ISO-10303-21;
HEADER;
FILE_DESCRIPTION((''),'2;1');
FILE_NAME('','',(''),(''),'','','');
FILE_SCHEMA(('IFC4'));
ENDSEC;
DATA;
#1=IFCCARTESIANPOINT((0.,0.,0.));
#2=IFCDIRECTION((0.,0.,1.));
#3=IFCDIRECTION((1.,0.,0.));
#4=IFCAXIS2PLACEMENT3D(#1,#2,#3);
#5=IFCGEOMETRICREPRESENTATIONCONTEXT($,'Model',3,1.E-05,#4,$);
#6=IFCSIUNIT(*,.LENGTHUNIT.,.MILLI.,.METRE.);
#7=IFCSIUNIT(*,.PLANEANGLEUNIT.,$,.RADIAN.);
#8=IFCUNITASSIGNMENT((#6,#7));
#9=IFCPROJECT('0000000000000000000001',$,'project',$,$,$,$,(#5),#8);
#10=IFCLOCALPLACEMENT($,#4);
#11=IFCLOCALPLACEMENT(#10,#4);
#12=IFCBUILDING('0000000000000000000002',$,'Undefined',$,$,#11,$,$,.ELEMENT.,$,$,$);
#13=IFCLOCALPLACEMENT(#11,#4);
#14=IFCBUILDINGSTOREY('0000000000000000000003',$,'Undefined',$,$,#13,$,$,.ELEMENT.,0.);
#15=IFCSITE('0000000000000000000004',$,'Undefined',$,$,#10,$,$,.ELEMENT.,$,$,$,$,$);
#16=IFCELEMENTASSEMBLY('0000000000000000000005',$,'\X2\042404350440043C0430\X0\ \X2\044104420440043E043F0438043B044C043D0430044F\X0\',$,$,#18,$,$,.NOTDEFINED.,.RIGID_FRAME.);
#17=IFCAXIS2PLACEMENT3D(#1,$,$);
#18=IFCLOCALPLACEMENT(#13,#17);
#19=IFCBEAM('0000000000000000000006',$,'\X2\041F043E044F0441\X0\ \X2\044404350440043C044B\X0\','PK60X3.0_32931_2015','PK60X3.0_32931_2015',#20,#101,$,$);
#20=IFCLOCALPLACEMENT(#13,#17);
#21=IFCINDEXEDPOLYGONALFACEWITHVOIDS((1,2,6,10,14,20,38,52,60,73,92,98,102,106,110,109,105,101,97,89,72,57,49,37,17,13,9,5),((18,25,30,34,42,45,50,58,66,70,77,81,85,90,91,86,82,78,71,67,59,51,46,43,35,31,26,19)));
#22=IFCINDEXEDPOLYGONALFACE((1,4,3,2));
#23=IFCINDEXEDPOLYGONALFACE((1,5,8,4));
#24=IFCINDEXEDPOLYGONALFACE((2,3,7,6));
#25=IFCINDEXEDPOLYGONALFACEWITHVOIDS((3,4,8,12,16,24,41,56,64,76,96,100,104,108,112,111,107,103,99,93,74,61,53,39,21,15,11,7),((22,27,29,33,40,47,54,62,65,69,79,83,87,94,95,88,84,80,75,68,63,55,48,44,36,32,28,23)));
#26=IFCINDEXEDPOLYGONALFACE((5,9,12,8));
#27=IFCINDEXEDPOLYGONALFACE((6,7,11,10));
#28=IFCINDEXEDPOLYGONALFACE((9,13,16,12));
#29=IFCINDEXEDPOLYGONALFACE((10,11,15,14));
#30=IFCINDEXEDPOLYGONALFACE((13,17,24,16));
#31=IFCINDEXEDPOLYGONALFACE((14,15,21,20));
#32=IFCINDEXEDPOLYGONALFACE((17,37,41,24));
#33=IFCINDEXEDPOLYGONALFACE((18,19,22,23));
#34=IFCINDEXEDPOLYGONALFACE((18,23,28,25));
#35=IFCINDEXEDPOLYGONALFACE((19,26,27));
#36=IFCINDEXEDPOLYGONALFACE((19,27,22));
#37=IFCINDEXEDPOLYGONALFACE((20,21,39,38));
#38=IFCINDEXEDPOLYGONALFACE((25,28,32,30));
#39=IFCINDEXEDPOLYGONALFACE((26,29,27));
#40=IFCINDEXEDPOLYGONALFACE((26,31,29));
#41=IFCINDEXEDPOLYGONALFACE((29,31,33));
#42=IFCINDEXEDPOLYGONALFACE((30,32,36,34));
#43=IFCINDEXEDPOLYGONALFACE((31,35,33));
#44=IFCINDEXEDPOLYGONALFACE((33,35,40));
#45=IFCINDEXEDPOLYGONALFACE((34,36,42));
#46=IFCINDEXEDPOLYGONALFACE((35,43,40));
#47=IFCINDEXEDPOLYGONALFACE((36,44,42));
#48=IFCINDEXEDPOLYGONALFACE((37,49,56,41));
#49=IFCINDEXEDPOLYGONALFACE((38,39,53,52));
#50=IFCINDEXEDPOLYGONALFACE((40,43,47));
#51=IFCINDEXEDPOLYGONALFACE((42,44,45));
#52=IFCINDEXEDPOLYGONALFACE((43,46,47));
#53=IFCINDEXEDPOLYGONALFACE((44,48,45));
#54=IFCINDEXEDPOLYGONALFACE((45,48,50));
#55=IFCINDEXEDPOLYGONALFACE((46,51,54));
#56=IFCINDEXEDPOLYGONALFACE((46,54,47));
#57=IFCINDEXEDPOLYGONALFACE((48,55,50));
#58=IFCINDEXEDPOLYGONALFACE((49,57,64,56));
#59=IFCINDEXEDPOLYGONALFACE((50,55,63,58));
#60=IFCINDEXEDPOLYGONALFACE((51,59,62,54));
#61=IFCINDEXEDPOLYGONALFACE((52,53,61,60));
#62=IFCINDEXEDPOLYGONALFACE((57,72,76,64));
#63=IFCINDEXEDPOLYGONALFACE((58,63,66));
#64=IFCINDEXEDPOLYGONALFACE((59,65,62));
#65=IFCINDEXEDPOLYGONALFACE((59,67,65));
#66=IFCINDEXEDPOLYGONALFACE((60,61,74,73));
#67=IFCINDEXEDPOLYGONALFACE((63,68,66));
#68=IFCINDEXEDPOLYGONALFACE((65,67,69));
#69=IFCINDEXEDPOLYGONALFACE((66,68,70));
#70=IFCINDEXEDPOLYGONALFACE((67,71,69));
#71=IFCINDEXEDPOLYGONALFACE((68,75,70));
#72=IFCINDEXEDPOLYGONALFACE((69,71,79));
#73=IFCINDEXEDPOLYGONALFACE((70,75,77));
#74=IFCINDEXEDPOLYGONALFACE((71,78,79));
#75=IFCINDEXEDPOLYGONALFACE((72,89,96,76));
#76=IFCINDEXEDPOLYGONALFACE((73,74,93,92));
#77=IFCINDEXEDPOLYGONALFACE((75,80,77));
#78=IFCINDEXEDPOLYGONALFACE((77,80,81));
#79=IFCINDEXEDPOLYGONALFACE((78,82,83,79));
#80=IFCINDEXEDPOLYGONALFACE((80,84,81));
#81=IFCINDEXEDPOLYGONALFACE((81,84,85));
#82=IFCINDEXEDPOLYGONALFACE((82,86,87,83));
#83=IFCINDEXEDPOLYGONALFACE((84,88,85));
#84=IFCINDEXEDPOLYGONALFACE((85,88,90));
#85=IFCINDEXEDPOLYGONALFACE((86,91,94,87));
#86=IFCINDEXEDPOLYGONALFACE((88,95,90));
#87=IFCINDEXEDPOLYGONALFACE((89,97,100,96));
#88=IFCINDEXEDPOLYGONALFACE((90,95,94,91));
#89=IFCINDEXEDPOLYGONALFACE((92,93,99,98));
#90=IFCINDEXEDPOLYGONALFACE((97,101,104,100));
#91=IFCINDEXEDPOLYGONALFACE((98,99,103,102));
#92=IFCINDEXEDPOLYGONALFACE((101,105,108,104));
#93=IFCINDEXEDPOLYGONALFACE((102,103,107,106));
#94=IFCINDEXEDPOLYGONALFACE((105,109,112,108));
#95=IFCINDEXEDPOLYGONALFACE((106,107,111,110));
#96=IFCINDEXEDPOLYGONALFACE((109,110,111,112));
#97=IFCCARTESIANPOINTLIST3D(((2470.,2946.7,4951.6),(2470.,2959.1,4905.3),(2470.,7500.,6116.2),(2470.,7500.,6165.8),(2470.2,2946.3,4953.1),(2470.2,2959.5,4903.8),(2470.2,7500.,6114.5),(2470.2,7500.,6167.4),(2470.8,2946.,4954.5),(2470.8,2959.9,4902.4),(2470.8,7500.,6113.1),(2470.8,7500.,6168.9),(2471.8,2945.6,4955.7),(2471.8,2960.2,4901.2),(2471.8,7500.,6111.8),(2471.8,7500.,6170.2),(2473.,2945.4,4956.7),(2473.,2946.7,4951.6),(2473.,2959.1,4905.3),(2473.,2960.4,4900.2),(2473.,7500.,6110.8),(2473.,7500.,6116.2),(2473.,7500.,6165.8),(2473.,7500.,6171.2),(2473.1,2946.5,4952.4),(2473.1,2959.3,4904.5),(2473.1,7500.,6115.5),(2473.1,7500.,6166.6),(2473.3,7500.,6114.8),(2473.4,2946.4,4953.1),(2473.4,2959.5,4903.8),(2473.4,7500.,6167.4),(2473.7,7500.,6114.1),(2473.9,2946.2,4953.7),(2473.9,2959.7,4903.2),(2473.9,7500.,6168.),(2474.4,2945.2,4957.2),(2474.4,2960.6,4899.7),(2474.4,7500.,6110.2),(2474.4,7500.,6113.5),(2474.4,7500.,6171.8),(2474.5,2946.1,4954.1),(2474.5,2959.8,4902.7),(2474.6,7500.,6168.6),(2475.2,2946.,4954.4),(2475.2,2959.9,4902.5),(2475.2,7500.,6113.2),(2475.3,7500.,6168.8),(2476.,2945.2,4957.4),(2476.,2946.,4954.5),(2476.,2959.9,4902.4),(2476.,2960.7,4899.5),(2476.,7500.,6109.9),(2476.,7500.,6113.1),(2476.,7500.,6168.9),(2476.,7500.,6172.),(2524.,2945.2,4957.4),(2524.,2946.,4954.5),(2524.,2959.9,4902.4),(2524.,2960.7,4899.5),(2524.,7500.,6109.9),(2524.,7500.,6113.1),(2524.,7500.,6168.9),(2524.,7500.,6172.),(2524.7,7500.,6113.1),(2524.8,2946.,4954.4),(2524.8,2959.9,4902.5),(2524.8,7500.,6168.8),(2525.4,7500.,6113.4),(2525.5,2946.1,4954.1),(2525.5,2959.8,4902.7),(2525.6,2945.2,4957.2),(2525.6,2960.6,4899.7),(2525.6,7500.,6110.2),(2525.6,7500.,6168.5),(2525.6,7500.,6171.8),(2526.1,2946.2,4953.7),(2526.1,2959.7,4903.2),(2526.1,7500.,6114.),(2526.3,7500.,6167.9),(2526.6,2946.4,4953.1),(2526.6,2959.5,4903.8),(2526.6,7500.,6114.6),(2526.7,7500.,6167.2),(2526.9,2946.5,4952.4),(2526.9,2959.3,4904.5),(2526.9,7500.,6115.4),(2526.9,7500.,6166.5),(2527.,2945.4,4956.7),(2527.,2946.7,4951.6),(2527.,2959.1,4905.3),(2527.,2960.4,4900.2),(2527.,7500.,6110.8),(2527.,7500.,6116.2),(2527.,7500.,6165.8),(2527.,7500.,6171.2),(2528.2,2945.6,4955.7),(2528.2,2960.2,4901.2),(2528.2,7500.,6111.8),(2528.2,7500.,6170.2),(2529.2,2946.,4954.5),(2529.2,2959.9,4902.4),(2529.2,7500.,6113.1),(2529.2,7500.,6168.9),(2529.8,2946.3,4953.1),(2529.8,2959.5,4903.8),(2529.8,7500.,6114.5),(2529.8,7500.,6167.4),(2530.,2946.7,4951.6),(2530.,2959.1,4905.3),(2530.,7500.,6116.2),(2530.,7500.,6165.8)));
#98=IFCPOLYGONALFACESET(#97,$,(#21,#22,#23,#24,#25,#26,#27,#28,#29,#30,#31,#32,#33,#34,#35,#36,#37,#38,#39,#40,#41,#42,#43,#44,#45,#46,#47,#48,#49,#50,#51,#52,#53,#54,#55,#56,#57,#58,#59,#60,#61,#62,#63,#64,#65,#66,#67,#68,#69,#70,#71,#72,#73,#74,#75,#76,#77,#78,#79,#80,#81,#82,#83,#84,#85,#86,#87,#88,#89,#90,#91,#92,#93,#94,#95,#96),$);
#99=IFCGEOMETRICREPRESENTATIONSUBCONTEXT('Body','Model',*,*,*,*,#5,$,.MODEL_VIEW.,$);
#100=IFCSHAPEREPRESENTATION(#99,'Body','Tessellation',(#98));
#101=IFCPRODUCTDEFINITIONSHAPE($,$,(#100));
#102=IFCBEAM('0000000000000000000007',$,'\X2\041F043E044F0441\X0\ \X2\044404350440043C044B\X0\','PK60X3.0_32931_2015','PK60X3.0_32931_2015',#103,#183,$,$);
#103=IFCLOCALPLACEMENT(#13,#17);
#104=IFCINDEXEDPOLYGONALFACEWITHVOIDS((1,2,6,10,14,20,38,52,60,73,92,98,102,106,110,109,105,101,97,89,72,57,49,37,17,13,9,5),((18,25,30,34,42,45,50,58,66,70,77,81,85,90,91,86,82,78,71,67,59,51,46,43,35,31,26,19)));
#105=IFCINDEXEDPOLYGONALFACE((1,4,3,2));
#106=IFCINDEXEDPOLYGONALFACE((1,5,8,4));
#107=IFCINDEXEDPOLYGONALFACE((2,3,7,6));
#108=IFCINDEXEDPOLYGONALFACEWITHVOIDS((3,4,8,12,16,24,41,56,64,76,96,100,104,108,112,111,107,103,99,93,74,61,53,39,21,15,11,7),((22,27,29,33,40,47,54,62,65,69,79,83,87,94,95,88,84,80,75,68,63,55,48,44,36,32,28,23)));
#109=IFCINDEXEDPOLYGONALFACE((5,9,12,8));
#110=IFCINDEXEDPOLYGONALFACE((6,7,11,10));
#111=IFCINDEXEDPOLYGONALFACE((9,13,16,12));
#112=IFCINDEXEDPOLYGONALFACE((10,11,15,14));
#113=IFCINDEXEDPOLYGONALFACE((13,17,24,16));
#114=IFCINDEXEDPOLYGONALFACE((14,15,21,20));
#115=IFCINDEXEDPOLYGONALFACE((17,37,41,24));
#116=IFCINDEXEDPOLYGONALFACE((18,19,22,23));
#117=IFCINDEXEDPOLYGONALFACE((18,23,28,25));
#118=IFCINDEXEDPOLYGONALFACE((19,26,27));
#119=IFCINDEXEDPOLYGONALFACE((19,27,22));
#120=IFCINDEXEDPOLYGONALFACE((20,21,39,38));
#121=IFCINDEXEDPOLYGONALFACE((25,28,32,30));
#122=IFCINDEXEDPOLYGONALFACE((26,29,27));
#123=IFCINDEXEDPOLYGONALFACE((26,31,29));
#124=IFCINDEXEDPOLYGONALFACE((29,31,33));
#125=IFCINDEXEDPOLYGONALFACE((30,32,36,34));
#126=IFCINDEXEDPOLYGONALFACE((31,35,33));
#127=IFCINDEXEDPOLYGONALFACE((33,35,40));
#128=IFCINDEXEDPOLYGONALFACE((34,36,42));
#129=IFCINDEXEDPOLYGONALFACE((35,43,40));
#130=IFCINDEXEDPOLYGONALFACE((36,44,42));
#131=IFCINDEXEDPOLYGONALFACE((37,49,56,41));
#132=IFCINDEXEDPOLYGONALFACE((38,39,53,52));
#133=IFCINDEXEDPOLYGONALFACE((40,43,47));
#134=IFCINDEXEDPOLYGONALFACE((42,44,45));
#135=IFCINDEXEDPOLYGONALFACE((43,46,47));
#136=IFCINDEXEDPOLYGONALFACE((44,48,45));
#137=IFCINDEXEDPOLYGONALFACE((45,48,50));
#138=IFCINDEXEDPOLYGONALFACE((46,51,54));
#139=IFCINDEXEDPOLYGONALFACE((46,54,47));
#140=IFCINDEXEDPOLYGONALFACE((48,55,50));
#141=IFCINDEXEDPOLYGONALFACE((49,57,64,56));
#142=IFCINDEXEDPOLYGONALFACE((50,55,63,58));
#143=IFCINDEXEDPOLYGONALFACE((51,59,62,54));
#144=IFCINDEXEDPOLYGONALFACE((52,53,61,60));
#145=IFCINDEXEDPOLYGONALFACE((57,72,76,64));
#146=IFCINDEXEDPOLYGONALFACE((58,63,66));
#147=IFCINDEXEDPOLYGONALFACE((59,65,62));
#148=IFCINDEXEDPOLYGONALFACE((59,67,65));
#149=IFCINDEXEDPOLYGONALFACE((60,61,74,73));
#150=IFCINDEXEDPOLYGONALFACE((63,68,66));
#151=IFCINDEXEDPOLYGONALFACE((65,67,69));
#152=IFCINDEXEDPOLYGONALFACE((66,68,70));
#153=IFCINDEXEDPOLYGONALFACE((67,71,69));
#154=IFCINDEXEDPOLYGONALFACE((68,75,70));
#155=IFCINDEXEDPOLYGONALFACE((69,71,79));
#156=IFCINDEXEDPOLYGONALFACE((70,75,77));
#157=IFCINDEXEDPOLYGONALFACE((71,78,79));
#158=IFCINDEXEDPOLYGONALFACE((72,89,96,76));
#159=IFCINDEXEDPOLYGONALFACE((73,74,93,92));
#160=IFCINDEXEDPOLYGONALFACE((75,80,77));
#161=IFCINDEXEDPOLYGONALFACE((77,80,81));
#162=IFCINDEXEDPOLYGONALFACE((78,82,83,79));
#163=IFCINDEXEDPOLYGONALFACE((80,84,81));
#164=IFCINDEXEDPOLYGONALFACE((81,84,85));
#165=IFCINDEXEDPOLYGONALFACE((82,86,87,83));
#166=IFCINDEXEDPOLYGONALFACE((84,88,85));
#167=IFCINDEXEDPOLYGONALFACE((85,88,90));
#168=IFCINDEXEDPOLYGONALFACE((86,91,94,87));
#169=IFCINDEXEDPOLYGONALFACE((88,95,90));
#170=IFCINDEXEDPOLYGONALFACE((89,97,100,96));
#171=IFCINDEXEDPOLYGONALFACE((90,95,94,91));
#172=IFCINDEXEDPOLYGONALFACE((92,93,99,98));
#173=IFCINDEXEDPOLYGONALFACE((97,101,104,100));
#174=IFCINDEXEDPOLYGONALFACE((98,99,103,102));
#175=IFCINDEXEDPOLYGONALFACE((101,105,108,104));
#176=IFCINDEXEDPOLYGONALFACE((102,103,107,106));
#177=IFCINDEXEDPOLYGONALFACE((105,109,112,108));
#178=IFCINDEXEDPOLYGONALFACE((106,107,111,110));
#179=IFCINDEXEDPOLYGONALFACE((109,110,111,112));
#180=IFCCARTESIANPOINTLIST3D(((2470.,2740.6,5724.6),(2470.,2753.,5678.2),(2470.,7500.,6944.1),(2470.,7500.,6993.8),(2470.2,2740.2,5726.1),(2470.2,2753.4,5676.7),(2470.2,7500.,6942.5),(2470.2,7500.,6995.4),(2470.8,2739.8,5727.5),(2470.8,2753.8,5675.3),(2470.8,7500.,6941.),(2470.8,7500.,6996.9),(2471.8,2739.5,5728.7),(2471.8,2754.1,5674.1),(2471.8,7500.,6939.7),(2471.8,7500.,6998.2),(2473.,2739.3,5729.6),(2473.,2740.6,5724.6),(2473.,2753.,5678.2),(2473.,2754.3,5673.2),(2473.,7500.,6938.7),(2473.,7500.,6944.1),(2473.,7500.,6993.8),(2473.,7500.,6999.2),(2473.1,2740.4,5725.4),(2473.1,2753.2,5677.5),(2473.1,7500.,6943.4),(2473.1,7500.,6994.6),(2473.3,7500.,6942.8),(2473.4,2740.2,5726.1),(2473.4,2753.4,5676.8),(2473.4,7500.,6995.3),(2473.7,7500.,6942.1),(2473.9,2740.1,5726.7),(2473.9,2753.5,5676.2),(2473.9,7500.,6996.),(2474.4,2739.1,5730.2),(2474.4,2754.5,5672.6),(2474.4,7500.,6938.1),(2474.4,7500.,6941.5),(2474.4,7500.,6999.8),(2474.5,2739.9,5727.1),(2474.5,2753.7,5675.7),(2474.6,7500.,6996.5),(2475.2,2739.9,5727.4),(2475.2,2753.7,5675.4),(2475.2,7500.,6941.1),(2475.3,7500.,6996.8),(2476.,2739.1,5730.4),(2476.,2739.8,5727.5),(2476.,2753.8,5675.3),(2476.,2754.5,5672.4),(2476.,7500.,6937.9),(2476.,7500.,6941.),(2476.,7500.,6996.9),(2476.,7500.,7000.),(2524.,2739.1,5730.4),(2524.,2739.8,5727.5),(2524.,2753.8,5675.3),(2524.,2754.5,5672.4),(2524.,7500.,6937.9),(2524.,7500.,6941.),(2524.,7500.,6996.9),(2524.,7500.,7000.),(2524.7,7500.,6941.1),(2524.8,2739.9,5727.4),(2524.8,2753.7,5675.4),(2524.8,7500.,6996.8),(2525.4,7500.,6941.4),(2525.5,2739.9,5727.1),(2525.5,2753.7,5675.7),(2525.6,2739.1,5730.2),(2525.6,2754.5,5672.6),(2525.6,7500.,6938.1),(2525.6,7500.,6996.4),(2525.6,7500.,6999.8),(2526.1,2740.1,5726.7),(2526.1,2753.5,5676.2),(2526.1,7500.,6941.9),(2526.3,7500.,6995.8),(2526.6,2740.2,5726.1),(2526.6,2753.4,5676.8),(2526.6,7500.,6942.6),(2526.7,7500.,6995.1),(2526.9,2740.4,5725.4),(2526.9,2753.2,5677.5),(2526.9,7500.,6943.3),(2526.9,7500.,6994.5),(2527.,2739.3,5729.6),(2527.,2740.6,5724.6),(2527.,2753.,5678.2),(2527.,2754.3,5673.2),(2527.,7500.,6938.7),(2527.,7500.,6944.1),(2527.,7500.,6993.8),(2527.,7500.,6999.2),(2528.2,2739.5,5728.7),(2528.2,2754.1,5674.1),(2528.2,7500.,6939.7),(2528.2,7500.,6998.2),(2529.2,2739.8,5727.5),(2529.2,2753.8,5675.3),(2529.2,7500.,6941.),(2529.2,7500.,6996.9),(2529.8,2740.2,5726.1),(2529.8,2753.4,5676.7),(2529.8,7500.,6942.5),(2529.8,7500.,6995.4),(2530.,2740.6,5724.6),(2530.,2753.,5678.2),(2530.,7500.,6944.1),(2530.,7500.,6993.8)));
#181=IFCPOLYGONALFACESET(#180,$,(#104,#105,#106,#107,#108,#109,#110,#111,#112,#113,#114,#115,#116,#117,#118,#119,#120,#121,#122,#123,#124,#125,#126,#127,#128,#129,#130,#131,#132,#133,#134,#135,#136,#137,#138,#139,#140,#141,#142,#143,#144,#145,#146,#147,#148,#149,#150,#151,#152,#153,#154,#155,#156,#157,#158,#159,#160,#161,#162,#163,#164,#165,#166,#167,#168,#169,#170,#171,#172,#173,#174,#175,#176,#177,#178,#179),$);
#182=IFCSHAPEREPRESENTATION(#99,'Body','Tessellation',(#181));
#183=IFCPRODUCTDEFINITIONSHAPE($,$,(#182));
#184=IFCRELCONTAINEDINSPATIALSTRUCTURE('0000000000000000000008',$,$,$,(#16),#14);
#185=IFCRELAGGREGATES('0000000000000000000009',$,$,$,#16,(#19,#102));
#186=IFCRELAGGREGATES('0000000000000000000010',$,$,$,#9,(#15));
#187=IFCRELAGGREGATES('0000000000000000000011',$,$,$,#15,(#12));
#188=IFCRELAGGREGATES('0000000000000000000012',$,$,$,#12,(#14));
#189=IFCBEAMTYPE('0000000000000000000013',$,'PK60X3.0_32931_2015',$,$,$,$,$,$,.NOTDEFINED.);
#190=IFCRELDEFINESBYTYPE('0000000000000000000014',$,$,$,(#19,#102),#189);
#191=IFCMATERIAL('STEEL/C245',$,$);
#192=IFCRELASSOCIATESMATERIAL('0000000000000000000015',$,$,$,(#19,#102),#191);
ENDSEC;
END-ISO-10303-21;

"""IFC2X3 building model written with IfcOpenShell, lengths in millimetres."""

from ifc_helpers import new_model, si_unit, frame, origin_with_axes, origin_2d_with_axis, place, context, subcontext, project, spatial, hollow_rectangle, extrude, clip, halfspace, material, type_object, element, aggregate, save


model = new_model("IFC2X3")

# Units and contexts
model_context = context("Model", 3, precision=1e-05, world=origin_with_axes())
body_context = subcontext(model_context, "Body", "Model", "MODEL_VIEW")
ifc_project = project(units=[si_unit("LENGTHUNIT", "METRE", prefix="MILLI"), si_unit("PLANEANGLEUNIT", "RADIAN")], contexts=[model_context])

# Site, building, storey
site_placement = place(None, origin_with_axes())
site = spatial("IfcSite", under=ifc_project, at=site_placement, Name="Undefined", CompositionType="ELEMENT")
building_placement = place(site_placement, origin_with_axes())
building = spatial("IfcBuilding", under=site, at=building_placement, Name="Undefined", CompositionType="ELEMENT")
storey_placement = place(building_placement, origin_with_axes())
storey = spatial("IfcBuildingStorey", under=building, at=storey_placement, Name="Undefined", CompositionType="ELEMENT", Elevation=0.0)

# Shared definitions
ifc_material_1 = material(Name="STEEL/C245")

# Element assembly, beams
beam_type_1 = type_object("IfcBeamType", Name="PK60X3.0_32931_2015", PredefinedType="NOTDEFINED")
assembly_1_placement = place(storey_placement, origin_with_axes())
assembly_1 = element("IfcElementAssembly", 1, at=assembly_1_placement, inside=storey, Name="Ферма стропильная", AssemblyPlace="NOTDEFINED", PredefinedType="RIGID_FRAME")
beam_1_placement = place(assembly_1_placement, frame((2500.0, 2952.9, 4928.4), z_axis=(0.0, -0.257663, 0.966235), x_axis=(0.0, 0.966235, 0.257663)))
beam_1 = element("IfcBeam", 2, at=beam_1_placement, type_object=beam_type_1, material=ifc_material_1, Name="Пояс фермы", Description="PK60X3.0_32931_2015", ObjectType="PK60X3.0_32931_2015", context=body_context, shape_type="Clipping", body=[
    clip(extrude(hollow_rectangle(XDim=60.0, YDim=60.0, WallThickness=3.0, InnerFilletRadius=3.0, OuterFilletRadius=6.0, at=origin_2d_with_axis()), frame((4729.1, 0.0, 0.0), z_axis=(-1.0, 0.0, 0.0), x_axis=(0.0, -1.0, 0.0)), (0.0, 0.0, 1.0), 4729.1), halfspace(frame((4938.1, 0.0, 870.5), z_axis=(0.966235, 0.0, -0.257663), x_axis=(0.0, -1.0, 0.0)), False)),
])
beam_2_placement = place(assembly_1_placement, frame((2500.0, 2746.8, 5701.4), z_axis=(0.0, -0.257663, 0.966235), x_axis=(0.0, 0.966235, 0.257663)))
beam_2 = element("IfcBeam", 3, at=beam_2_placement, type_object=beam_type_1, material=ifc_material_1, Name="Пояс фермы", Description="PK60X3.0_32931_2015", ObjectType="PK60X3.0_32931_2015", context=body_context, shape_type="Clipping", body=[
    clip(extrude(hollow_rectangle(XDim=60.0, YDim=60.0, WallThickness=3.0, InnerFilletRadius=3.0, OuterFilletRadius=6.0, at=origin_2d_with_axis()), frame((4942.5, 0.0, 0.0), z_axis=(-1.0, 0.0, 0.0), x_axis=(0.0, -1.0, 0.0)), (0.0, 0.0, 1.0), 4942.5), halfspace(frame((4938.1, 0.0, 70.5), z_axis=(0.966235, 0.0, -0.257663), x_axis=(0.0, -1.0, 0.0)), False)),
])

aggregate(assembly_1, [beam_1, beam_2])

save(model, "model.ifc")
